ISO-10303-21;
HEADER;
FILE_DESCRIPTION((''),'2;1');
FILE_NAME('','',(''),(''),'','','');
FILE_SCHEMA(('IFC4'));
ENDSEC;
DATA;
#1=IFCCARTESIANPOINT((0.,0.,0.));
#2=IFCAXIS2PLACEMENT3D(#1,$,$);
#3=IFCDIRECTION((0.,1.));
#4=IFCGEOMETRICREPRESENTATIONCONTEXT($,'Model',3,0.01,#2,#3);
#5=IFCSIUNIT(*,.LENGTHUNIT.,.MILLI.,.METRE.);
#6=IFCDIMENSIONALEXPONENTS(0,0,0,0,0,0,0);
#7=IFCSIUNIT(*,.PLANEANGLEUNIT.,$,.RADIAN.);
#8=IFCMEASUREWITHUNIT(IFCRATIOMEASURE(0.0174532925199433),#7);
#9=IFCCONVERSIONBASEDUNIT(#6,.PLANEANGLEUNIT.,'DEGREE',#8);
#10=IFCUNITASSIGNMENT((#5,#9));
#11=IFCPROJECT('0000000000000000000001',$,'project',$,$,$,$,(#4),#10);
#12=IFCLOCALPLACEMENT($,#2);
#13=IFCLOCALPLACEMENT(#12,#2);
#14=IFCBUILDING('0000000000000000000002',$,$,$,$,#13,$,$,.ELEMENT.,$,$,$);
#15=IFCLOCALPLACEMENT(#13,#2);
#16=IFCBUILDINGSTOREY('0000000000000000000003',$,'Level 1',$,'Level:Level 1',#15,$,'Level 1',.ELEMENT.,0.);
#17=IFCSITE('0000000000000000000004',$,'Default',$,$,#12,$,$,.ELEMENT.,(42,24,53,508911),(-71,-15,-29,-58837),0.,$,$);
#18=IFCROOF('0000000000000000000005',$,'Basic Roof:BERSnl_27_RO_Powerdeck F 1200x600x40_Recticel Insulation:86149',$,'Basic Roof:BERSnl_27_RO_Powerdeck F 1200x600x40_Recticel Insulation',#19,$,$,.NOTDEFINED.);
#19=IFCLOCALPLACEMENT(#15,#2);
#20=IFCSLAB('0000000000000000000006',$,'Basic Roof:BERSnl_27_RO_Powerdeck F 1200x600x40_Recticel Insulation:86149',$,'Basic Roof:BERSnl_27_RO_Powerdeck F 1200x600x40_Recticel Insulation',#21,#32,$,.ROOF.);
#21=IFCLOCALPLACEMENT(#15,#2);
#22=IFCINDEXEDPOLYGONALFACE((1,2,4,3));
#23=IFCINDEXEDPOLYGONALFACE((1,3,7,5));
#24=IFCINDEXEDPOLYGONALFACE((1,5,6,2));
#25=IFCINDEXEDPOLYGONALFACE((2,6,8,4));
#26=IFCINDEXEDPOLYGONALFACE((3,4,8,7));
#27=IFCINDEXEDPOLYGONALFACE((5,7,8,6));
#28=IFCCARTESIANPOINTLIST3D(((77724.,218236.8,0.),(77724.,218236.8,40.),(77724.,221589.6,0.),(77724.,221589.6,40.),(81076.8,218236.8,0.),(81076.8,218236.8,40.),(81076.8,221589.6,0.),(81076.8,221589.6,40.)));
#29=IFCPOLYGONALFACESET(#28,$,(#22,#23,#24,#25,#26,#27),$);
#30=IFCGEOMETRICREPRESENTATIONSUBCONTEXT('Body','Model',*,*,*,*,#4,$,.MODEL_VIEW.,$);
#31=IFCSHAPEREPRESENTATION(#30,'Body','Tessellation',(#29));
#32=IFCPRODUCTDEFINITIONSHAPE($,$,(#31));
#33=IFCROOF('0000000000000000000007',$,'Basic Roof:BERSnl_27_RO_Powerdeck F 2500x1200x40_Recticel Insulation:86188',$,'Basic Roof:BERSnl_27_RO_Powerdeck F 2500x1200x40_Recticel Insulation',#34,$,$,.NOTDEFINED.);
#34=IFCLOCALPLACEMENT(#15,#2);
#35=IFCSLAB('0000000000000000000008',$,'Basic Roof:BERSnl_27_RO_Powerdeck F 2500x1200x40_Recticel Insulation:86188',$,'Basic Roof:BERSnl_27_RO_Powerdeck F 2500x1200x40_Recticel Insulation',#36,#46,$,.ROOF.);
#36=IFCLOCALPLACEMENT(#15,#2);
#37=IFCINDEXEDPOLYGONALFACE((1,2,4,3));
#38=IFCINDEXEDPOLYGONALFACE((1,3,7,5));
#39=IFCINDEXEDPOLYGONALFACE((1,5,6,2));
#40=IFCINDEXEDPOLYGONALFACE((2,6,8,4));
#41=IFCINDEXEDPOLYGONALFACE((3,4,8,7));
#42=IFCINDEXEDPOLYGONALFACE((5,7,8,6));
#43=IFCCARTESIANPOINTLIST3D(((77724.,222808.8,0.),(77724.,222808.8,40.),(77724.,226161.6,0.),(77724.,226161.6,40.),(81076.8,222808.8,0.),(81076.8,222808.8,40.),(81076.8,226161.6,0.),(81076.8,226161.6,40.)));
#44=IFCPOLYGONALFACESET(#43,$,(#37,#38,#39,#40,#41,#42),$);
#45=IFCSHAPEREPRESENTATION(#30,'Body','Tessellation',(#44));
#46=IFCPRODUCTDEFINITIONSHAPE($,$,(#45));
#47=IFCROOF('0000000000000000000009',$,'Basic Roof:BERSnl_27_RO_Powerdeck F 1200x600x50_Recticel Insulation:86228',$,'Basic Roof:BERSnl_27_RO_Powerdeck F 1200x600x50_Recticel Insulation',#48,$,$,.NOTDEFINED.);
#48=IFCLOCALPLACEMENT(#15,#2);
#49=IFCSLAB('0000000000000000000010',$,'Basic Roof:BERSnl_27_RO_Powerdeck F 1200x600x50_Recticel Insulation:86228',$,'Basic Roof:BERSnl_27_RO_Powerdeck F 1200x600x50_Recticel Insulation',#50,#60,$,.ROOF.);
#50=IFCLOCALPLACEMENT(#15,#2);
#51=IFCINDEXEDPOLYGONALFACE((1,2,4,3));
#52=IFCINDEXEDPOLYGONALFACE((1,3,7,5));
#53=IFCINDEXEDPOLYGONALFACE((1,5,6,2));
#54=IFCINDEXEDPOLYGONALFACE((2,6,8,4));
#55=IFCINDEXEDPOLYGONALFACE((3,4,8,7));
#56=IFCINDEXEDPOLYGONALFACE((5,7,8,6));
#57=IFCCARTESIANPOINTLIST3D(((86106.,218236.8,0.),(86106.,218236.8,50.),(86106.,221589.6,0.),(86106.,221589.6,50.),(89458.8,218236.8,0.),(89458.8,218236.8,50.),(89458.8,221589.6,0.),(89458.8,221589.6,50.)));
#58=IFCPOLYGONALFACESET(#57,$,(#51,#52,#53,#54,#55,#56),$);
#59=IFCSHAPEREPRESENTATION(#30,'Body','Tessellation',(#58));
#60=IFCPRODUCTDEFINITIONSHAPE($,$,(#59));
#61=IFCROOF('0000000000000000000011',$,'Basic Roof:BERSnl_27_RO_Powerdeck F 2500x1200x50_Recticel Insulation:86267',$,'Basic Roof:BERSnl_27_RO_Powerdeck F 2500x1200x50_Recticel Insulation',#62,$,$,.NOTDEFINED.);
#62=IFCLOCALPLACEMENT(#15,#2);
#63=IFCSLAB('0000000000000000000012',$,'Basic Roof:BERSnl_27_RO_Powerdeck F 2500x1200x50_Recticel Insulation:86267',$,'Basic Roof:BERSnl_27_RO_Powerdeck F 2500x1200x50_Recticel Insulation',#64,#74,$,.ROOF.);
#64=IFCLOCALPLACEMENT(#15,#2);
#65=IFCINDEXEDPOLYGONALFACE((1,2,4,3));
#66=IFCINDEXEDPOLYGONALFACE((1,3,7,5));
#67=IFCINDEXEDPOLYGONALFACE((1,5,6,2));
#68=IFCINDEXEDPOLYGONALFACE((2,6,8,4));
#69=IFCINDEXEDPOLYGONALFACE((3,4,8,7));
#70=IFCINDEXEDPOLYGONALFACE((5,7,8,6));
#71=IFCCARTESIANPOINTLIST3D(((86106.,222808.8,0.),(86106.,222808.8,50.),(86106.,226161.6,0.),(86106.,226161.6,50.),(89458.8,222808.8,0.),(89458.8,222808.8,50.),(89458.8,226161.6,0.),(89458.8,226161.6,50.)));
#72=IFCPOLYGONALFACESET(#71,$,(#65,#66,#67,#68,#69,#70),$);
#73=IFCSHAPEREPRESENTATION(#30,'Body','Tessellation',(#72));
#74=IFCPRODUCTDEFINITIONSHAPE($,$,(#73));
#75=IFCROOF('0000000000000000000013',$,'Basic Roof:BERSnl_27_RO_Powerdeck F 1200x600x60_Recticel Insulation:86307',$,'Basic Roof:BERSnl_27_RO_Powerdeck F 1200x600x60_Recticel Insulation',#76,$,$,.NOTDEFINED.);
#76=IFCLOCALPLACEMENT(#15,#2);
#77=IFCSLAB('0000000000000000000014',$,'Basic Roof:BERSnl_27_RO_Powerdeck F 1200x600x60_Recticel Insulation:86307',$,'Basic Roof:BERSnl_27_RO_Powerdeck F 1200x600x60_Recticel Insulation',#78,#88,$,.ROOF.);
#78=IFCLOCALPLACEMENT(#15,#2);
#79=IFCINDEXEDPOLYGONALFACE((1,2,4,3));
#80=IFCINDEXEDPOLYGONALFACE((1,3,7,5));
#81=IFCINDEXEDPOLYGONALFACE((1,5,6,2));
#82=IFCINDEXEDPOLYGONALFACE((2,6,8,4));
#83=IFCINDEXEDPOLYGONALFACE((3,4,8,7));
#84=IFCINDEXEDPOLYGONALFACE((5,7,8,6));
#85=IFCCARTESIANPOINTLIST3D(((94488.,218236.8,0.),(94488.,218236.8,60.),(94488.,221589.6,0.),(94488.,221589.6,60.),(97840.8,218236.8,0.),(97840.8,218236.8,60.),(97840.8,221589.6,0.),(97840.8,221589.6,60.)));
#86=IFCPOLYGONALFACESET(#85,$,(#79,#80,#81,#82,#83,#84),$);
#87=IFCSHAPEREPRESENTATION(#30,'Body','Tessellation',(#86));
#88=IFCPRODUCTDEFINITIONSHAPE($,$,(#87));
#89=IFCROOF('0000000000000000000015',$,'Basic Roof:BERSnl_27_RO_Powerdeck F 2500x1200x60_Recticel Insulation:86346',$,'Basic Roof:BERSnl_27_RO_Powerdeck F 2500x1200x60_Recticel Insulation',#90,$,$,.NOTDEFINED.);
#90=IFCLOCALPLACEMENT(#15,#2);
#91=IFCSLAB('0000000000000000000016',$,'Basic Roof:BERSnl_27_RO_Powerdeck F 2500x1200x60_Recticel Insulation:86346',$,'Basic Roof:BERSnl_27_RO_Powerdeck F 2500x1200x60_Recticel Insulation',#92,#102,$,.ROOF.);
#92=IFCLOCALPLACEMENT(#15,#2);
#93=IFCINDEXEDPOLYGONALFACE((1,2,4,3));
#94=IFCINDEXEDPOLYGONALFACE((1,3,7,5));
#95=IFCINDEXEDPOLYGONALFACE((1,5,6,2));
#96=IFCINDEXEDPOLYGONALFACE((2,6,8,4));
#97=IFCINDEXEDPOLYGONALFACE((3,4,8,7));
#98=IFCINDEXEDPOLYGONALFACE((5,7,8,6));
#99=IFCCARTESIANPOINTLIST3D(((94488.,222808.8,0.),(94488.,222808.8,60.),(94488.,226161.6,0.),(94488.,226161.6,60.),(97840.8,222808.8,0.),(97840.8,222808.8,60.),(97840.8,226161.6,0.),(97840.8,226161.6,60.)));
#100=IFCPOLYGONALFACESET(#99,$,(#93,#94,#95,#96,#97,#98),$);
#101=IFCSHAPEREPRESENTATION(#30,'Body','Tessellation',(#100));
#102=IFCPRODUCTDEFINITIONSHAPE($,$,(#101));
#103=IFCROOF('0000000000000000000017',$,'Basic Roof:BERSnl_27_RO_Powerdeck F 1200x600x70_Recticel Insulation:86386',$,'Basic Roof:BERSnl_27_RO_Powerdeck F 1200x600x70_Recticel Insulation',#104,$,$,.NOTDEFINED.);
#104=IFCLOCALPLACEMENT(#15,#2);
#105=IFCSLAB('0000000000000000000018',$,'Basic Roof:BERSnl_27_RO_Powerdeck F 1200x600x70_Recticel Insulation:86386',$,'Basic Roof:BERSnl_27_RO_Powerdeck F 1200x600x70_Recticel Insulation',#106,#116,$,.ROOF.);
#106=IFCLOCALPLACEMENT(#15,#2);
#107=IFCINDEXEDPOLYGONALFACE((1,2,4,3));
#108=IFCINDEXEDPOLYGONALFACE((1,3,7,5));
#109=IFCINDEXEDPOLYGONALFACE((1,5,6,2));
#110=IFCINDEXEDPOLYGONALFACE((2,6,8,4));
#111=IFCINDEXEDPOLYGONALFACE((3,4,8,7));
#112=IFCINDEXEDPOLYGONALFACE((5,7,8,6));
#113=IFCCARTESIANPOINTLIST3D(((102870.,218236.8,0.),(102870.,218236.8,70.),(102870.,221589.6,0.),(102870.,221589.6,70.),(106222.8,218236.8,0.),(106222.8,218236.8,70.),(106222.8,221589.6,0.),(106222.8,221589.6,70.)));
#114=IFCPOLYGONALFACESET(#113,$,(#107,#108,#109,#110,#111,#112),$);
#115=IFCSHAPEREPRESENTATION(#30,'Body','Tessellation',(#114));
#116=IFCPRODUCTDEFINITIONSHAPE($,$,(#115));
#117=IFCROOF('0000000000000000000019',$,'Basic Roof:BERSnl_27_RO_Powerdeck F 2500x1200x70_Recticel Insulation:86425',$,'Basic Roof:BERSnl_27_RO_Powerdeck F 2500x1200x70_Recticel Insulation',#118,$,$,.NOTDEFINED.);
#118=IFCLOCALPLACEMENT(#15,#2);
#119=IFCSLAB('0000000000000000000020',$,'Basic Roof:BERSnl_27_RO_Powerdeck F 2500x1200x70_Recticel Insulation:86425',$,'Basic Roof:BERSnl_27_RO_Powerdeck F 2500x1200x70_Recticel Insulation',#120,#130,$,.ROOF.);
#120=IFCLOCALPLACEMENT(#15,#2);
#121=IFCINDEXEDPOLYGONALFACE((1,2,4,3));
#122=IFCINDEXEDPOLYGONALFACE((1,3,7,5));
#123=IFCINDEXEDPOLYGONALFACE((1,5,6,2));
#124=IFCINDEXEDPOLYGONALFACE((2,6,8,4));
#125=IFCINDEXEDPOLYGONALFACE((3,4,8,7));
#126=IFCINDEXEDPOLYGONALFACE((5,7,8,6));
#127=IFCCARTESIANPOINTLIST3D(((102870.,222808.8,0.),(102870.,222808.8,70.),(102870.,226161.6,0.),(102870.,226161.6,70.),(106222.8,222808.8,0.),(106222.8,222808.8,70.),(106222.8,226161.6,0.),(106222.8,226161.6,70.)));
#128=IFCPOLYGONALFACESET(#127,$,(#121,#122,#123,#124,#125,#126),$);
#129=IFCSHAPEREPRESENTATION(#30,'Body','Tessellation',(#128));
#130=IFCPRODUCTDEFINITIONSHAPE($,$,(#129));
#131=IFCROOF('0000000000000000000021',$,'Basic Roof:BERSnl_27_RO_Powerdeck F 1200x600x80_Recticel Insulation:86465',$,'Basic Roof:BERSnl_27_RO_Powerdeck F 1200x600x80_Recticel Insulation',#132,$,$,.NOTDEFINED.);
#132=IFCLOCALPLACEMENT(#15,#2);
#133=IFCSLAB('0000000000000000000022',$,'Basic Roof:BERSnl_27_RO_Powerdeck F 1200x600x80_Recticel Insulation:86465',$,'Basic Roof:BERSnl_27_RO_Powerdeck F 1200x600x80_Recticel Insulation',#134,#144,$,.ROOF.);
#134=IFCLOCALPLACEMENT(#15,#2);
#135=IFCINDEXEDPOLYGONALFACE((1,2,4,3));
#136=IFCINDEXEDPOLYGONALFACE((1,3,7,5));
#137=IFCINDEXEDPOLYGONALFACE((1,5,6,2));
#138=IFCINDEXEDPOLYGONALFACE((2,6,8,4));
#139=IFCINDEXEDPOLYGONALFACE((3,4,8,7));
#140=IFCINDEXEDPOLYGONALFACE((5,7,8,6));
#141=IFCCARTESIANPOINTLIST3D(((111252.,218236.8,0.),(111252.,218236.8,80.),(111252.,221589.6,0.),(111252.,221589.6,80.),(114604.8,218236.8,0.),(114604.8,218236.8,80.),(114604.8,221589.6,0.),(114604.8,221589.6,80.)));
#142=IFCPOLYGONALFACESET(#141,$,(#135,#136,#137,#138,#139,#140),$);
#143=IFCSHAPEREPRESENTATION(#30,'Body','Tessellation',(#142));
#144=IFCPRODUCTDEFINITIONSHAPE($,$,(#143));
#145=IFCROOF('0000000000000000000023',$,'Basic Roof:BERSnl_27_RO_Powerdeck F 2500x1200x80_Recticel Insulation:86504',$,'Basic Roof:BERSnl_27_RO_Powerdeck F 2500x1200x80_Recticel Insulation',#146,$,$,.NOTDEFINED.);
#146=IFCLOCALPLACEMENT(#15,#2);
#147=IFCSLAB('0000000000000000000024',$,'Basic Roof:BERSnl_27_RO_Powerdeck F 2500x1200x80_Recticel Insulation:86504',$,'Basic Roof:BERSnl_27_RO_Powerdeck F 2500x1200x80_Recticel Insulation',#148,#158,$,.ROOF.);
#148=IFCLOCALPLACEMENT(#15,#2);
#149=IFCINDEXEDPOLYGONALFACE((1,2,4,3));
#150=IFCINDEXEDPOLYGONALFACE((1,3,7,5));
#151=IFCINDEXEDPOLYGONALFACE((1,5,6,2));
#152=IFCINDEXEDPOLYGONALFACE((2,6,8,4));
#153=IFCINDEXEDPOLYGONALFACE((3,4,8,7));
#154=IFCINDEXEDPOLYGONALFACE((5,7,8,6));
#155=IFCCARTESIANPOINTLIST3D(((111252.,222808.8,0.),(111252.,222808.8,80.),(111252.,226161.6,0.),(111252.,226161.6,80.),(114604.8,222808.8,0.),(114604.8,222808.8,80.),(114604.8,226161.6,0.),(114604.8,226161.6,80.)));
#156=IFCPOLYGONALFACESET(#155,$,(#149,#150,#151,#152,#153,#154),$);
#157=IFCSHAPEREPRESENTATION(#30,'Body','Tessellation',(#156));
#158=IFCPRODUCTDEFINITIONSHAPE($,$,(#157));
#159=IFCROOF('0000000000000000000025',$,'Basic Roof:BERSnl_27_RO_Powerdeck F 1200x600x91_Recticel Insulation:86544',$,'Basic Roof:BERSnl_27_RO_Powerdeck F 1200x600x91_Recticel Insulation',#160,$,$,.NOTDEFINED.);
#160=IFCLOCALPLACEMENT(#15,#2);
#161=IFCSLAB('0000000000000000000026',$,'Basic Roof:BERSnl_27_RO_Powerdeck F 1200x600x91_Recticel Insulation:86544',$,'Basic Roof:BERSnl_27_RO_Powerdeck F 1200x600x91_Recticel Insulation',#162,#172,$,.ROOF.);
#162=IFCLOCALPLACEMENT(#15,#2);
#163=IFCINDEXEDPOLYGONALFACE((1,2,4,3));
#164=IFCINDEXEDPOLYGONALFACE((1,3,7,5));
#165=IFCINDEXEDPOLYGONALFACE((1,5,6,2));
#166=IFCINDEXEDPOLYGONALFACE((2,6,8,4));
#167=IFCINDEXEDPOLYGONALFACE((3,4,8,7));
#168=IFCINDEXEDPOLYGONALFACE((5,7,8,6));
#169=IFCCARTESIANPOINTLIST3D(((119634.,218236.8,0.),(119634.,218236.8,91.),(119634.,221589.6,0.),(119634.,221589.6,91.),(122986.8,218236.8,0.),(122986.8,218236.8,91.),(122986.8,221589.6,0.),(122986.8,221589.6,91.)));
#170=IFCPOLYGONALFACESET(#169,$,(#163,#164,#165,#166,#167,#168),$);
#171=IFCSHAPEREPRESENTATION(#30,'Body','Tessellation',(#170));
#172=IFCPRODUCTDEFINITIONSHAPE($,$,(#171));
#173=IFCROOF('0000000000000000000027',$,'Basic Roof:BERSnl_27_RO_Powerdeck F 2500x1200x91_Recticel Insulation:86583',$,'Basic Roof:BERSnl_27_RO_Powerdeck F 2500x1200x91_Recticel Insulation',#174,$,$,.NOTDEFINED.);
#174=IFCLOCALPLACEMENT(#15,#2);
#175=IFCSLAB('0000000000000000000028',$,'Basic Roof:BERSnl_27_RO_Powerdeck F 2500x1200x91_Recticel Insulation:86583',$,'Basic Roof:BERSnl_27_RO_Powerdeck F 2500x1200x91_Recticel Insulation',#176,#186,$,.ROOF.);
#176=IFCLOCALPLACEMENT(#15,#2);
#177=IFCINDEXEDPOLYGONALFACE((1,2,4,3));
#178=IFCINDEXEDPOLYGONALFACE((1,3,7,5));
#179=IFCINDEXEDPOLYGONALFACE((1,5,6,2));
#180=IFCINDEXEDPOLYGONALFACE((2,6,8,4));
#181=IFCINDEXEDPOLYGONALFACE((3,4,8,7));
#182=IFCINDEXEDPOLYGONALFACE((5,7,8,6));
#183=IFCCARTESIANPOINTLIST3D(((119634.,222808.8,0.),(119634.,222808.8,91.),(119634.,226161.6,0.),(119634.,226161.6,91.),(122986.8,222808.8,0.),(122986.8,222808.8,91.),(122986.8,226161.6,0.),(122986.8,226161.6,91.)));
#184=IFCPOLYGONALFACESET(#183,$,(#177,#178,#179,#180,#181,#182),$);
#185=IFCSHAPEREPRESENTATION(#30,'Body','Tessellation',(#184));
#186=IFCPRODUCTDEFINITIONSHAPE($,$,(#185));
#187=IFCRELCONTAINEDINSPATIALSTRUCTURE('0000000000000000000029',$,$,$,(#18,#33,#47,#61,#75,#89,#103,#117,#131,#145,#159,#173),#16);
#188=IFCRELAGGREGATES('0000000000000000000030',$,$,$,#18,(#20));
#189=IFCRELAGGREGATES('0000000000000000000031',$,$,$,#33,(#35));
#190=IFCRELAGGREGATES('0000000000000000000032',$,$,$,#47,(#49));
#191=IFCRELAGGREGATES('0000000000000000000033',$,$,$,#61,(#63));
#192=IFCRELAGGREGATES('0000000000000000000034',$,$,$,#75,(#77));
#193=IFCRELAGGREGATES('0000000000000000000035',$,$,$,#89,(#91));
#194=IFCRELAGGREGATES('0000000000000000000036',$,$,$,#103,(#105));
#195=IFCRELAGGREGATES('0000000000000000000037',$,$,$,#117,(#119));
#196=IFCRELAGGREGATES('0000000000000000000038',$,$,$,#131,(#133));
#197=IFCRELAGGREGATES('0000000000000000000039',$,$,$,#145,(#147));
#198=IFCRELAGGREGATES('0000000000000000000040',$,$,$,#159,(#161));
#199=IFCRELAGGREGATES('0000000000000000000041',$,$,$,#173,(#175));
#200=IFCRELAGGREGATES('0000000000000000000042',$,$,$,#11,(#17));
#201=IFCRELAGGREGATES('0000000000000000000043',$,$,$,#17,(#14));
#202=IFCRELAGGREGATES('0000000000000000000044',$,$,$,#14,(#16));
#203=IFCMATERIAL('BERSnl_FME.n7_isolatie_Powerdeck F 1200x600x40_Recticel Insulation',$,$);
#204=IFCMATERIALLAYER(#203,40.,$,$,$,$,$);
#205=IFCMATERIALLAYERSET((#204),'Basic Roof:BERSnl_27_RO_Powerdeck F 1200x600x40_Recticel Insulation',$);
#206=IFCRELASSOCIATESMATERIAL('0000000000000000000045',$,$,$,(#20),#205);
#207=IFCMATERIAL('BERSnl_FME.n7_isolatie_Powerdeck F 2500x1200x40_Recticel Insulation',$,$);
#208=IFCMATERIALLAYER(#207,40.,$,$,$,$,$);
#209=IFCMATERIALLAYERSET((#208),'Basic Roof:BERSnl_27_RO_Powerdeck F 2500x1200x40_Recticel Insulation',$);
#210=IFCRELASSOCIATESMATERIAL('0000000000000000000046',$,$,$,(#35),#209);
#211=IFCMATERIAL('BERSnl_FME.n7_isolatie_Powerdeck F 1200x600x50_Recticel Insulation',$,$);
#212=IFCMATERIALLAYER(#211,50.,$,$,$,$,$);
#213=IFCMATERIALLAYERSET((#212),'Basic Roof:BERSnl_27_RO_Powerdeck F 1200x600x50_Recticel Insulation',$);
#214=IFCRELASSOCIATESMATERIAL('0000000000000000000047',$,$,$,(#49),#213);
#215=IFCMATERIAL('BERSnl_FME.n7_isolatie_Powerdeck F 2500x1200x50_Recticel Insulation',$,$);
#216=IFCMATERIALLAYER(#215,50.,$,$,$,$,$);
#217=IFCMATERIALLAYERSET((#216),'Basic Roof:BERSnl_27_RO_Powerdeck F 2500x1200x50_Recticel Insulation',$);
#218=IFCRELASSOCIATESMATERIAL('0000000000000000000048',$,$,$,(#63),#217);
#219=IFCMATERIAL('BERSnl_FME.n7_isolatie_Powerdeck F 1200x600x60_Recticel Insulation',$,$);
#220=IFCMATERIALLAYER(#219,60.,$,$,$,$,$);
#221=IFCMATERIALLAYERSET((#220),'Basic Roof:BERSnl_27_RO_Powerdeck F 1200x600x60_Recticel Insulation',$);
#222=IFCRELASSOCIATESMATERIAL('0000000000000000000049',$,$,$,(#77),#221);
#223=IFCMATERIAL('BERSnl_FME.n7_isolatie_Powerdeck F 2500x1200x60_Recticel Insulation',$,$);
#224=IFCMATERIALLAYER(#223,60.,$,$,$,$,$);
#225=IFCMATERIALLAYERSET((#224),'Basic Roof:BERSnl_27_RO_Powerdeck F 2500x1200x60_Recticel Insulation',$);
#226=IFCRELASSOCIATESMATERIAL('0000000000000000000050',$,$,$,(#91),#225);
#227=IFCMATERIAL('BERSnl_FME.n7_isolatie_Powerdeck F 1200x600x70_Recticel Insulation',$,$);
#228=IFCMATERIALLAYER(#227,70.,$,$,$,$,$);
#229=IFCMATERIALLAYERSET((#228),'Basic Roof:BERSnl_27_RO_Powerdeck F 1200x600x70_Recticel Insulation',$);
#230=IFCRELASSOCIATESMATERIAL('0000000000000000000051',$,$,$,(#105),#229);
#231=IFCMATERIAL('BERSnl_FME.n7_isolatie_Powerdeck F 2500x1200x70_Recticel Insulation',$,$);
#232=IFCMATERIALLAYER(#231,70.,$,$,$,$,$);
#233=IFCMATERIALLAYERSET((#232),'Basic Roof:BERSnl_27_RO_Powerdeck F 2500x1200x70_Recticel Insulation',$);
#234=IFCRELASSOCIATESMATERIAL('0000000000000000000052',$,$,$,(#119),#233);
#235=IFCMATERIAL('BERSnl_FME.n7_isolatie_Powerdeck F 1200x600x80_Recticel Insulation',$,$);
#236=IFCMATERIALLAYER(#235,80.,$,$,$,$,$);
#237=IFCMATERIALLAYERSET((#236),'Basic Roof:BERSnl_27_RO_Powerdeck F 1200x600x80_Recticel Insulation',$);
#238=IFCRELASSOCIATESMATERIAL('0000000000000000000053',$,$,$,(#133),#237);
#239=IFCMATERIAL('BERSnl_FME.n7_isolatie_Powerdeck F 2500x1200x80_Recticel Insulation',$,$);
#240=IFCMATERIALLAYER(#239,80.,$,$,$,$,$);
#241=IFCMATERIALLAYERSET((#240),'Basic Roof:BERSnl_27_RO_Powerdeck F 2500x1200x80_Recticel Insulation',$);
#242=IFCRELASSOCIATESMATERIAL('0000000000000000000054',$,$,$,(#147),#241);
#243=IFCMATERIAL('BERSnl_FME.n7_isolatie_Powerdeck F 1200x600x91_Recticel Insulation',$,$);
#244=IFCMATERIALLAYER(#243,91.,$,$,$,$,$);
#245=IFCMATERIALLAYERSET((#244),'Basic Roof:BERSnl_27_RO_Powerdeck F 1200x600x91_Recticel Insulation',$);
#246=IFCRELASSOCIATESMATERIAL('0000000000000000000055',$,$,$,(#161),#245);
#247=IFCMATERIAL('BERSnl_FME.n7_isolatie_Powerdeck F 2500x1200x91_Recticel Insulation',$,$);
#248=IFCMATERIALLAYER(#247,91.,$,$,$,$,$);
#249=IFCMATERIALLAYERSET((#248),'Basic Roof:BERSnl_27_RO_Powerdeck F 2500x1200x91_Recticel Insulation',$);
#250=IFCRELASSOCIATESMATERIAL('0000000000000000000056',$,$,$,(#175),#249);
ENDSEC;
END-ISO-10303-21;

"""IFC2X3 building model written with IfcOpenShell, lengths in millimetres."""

from ifc_helpers import new_model, entity, si_unit, converted_unit, direction, frame, frame_2d, origin, place, context, subcontext, project, spatial, rectangle, extrude, material, layer, layer_set, element, aggregate, save


model = new_model("IFC2X3")

# Units and contexts
model_context = context("Model", 3, precision=0.01, world=origin(), true_north=direction((0.0, 1.0)))
body_context = subcontext(model_context, "Body", "Model", "MODEL_VIEW")
ifc_project = project(units=[si_unit("LENGTHUNIT", "METRE", prefix="MILLI"), converted_unit("PLANEANGLEUNIT", "DEGREE", entity("IfcRatioMeasure", 0.0174532925199433), si_unit("PLANEANGLEUNIT", "RADIAN"), dimensions=[0, 0, 0, 0, 0, 0, 0])], contexts=[model_context])

# Site, building, storey
site_placement = place(None, origin())
site = spatial("IfcSite", under=ifc_project, at=site_placement, Name="Default", CompositionType="ELEMENT", RefLatitude=(42, 24, 53, 508911), RefLongitude=(-71, -15, -29, -58837), RefElevation=0.0)
building_placement = place(site_placement, origin())
building = spatial("IfcBuilding", under=site, at=building_placement, CompositionType="ELEMENT")
storey_placement = place(building_placement, origin())
storey = spatial("IfcBuildingStorey", under=building, at=storey_placement, Name="Level 1", ObjectType="Level:Level 1", LongName="Level 1", CompositionType="ELEMENT", Elevation=0.0)

# Roofs, slabs
roof_1_placement = place(storey_placement, frame((77724.0, 218236.8, 0.0)))
roof_1 = element("IfcRoof", 1, at=roof_1_placement, inside=storey, Name="Basic Roof:BERSnl_27_RO_Powerdeck F 1200x600x40_Recticel Insulation:86149", ObjectType="Basic Roof:BERSnl_27_RO_Powerdeck F 1200x600x40_Recticel Insulation", ShapeType="NOTDEFINED")
ifc_material_1 = material(Name="BERSnl_FME.n7_isolatie_Powerdeck F 1200x600x40_Recticel Insulation")
ifc_layer_1 = layer(ifc_material_1, 40.0)
ifc_layer_set_1 = layer_set([ifc_layer_1], Name="Basic Roof:BERSnl_27_RO_Powerdeck F 1200x600x40_Recticel Insulation")
slab_1_placement = place(roof_1_placement, origin())
slab_1 = element("IfcSlab", 2, at=slab_1_placement, material=ifc_layer_set_1, Name="Basic Roof:BERSnl_27_RO_Powerdeck F 1200x600x40_Recticel Insulation:86149", ObjectType="Basic Roof:BERSnl_27_RO_Powerdeck F 1200x600x40_Recticel Insulation", PredefinedType="ROOF", context=body_context, shape_type="SweptSolid", body=[
    extrude(rectangle(XDim=3352.8, YDim=3352.8, at=frame_2d((0.0, 0.0), x_axis=(-1.0, 0.0))), frame((1676.4, 1676.4, 0.0)), (0.0, 0.0, 1.0), 40.0),
])
aggregate(roof_1, [slab_1])
roof_2_placement = place(storey_placement, frame((77724.0, 222808.8, 0.0)))
roof_2 = element("IfcRoof", 3, at=roof_2_placement, inside=storey, Name="Basic Roof:BERSnl_27_RO_Powerdeck F 2500x1200x40_Recticel Insulation:86188", ObjectType="Basic Roof:BERSnl_27_RO_Powerdeck F 2500x1200x40_Recticel Insulation", ShapeType="NOTDEFINED")
ifc_material_2 = material(Name="BERSnl_FME.n7_isolatie_Powerdeck F 2500x1200x40_Recticel Insulation")
ifc_layer_2 = layer(ifc_material_2, 40.0)
ifc_layer_set_2 = layer_set([ifc_layer_2], Name="Basic Roof:BERSnl_27_RO_Powerdeck F 2500x1200x40_Recticel Insulation")
slab_2_placement = place(roof_2_placement, origin())
slab_2 = element("IfcSlab", 4, at=slab_2_placement, material=ifc_layer_set_2, Name="Basic Roof:BERSnl_27_RO_Powerdeck F 2500x1200x40_Recticel Insulation:86188", ObjectType="Basic Roof:BERSnl_27_RO_Powerdeck F 2500x1200x40_Recticel Insulation", PredefinedType="ROOF", context=body_context, shape_type="SweptSolid", body=[
    extrude(rectangle(XDim=3352.8, YDim=3352.8, at=frame_2d((0.0, 0.0), x_axis=(-1.0, 0.0))), frame((1676.4, 1676.4, 0.0)), (0.0, 0.0, 1.0), 40.0),
])
aggregate(roof_2, [slab_2])
roof_3_placement = place(storey_placement, frame((86106.0, 218236.8, 0.0)))
roof_3 = element("IfcRoof", 5, at=roof_3_placement, inside=storey, Name="Basic Roof:BERSnl_27_RO_Powerdeck F 1200x600x50_Recticel Insulation:86228", ObjectType="Basic Roof:BERSnl_27_RO_Powerdeck F 1200x600x50_Recticel Insulation", ShapeType="NOTDEFINED")
ifc_material_3 = material(Name="BERSnl_FME.n7_isolatie_Powerdeck F 1200x600x50_Recticel Insulation")
ifc_layer_3 = layer(ifc_material_3, 50.0)
ifc_layer_set_3 = layer_set([ifc_layer_3], Name="Basic Roof:BERSnl_27_RO_Powerdeck F 1200x600x50_Recticel Insulation")
slab_3_placement = place(roof_3_placement, origin())
slab_3 = element("IfcSlab", 6, at=slab_3_placement, material=ifc_layer_set_3, Name="Basic Roof:BERSnl_27_RO_Powerdeck F 1200x600x50_Recticel Insulation:86228", ObjectType="Basic Roof:BERSnl_27_RO_Powerdeck F 1200x600x50_Recticel Insulation", PredefinedType="ROOF", context=body_context, shape_type="SweptSolid", body=[
    extrude(rectangle(XDim=3352.8, YDim=3352.8, at=frame_2d((0.0, 0.0), x_axis=(-1.0, 0.0))), frame((1676.4, 1676.4, 0.0)), (0.0, 0.0, 1.0), 50.0),
])
aggregate(roof_3, [slab_3])
roof_4_placement = place(storey_placement, frame((86106.0, 222808.8, 0.0)))
roof_4 = element("IfcRoof", 7, at=roof_4_placement, inside=storey, Name="Basic Roof:BERSnl_27_RO_Powerdeck F 2500x1200x50_Recticel Insulation:86267", ObjectType="Basic Roof:BERSnl_27_RO_Powerdeck F 2500x1200x50_Recticel Insulation", ShapeType="NOTDEFINED")
ifc_material_4 = material(Name="BERSnl_FME.n7_isolatie_Powerdeck F 2500x1200x50_Recticel Insulation")
ifc_layer_4 = layer(ifc_material_4, 50.0)
ifc_layer_set_4 = layer_set([ifc_layer_4], Name="Basic Roof:BERSnl_27_RO_Powerdeck F 2500x1200x50_Recticel Insulation")
slab_4_placement = place(roof_4_placement, origin())
slab_4 = element("IfcSlab", 8, at=slab_4_placement, material=ifc_layer_set_4, Name="Basic Roof:BERSnl_27_RO_Powerdeck F 2500x1200x50_Recticel Insulation:86267", ObjectType="Basic Roof:BERSnl_27_RO_Powerdeck F 2500x1200x50_Recticel Insulation", PredefinedType="ROOF", context=body_context, shape_type="SweptSolid", body=[
    extrude(rectangle(XDim=3352.8, YDim=3352.8, at=frame_2d((0.0, 0.0), x_axis=(-1.0, 0.0))), frame((1676.4, 1676.4, 0.0)), (0.0, 0.0, 1.0), 50.0),
])
aggregate(roof_4, [slab_4])
roof_5_placement = place(storey_placement, frame((94488.0, 218236.8, 0.0)))
roof_5 = element("IfcRoof", 9, at=roof_5_placement, inside=storey, Name="Basic Roof:BERSnl_27_RO_Powerdeck F 1200x600x60_Recticel Insulation:86307", ObjectType="Basic Roof:BERSnl_27_RO_Powerdeck F 1200x600x60_Recticel Insulation", ShapeType="NOTDEFINED")
ifc_material_5 = material(Name="BERSnl_FME.n7_isolatie_Powerdeck F 1200x600x60_Recticel Insulation")
ifc_layer_5 = layer(ifc_material_5, 60.0)
ifc_layer_set_5 = layer_set([ifc_layer_5], Name="Basic Roof:BERSnl_27_RO_Powerdeck F 1200x600x60_Recticel Insulation")
slab_5_placement = place(roof_5_placement, origin())
slab_5 = element("IfcSlab", 10, at=slab_5_placement, material=ifc_layer_set_5, Name="Basic Roof:BERSnl_27_RO_Powerdeck F 1200x600x60_Recticel Insulation:86307", ObjectType="Basic Roof:BERSnl_27_RO_Powerdeck F 1200x600x60_Recticel Insulation", PredefinedType="ROOF", context=body_context, shape_type="SweptSolid", body=[
    extrude(rectangle(XDim=3352.8, YDim=3352.8, at=frame_2d((0.0, 0.0), x_axis=(-1.0, 0.0))), frame((1676.4, 1676.4, 0.0)), (0.0, 0.0, 1.0), 60.0),
])
aggregate(roof_5, [slab_5])
roof_6_placement = place(storey_placement, frame((94488.0, 222808.8, 0.0)))
roof_6 = element("IfcRoof", 11, at=roof_6_placement, inside=storey, Name="Basic Roof:BERSnl_27_RO_Powerdeck F 2500x1200x60_Recticel Insulation:86346", ObjectType="Basic Roof:BERSnl_27_RO_Powerdeck F 2500x1200x60_Recticel Insulation", ShapeType="NOTDEFINED")
ifc_material_6 = material(Name="BERSnl_FME.n7_isolatie_Powerdeck F 2500x1200x60_Recticel Insulation")
ifc_layer_6 = layer(ifc_material_6, 60.0)
ifc_layer_set_6 = layer_set([ifc_layer_6], Name="Basic Roof:BERSnl_27_RO_Powerdeck F 2500x1200x60_Recticel Insulation")
slab_6_placement = place(roof_6_placement, origin())
slab_6 = element("IfcSlab", 12, at=slab_6_placement, material=ifc_layer_set_6, Name="Basic Roof:BERSnl_27_RO_Powerdeck F 2500x1200x60_Recticel Insulation:86346", ObjectType="Basic Roof:BERSnl_27_RO_Powerdeck F 2500x1200x60_Recticel Insulation", PredefinedType="ROOF", context=body_context, shape_type="SweptSolid", body=[
    extrude(rectangle(XDim=3352.8, YDim=3352.8, at=frame_2d((0.0, 0.0), x_axis=(-1.0, 0.0))), frame((1676.4, 1676.4, 0.0)), (0.0, 0.0, 1.0), 60.0),
])
aggregate(roof_6, [slab_6])
roof_7_placement = place(storey_placement, frame((102870.0, 218236.8, 0.0)))
roof_7 = element("IfcRoof", 13, at=roof_7_placement, inside=storey, Name="Basic Roof:BERSnl_27_RO_Powerdeck F 1200x600x70_Recticel Insulation:86386", ObjectType="Basic Roof:BERSnl_27_RO_Powerdeck F 1200x600x70_Recticel Insulation", ShapeType="NOTDEFINED")
ifc_material_7 = material(Name="BERSnl_FME.n7_isolatie_Powerdeck F 1200x600x70_Recticel Insulation")
ifc_layer_7 = layer(ifc_material_7, 70.0)
ifc_layer_set_7 = layer_set([ifc_layer_7], Name="Basic Roof:BERSnl_27_RO_Powerdeck F 1200x600x70_Recticel Insulation")
slab_7_placement = place(roof_7_placement, origin())
slab_7 = element("IfcSlab", 14, at=slab_7_placement, material=ifc_layer_set_7, Name="Basic Roof:BERSnl_27_RO_Powerdeck F 1200x600x70_Recticel Insulation:86386", ObjectType="Basic Roof:BERSnl_27_RO_Powerdeck F 1200x600x70_Recticel Insulation", PredefinedType="ROOF", context=body_context, shape_type="SweptSolid", body=[
    extrude(rectangle(XDim=3352.8, YDim=3352.8, at=frame_2d((0.0, 0.0), x_axis=(-1.0, 0.0))), frame((1676.4, 1676.4, 0.0)), (0.0, 0.0, 1.0), 70.0),
])
aggregate(roof_7, [slab_7])
roof_8_placement = place(storey_placement, frame((102870.0, 222808.8, 0.0)))
roof_8 = element("IfcRoof", 15, at=roof_8_placement, inside=storey, Name="Basic Roof:BERSnl_27_RO_Powerdeck F 2500x1200x70_Recticel Insulation:86425", ObjectType="Basic Roof:BERSnl_27_RO_Powerdeck F 2500x1200x70_Recticel Insulation", ShapeType="NOTDEFINED")
ifc_material_8 = material(Name="BERSnl_FME.n7_isolatie_Powerdeck F 2500x1200x70_Recticel Insulation")
ifc_layer_8 = layer(ifc_material_8, 70.0)
ifc_layer_set_8 = layer_set([ifc_layer_8], Name="Basic Roof:BERSnl_27_RO_Powerdeck F 2500x1200x70_Recticel Insulation")
slab_8_placement = place(roof_8_placement, origin())
slab_8 = element("IfcSlab", 16, at=slab_8_placement, material=ifc_layer_set_8, Name="Basic Roof:BERSnl_27_RO_Powerdeck F 2500x1200x70_Recticel Insulation:86425", ObjectType="Basic Roof:BERSnl_27_RO_Powerdeck F 2500x1200x70_Recticel Insulation", PredefinedType="ROOF", context=body_context, shape_type="SweptSolid", body=[
    extrude(rectangle(XDim=3352.8, YDim=3352.8, at=frame_2d((0.0, 0.0), x_axis=(-1.0, 0.0))), frame((1676.4, 1676.4, 0.0)), (0.0, 0.0, 1.0), 70.0),
])
aggregate(roof_8, [slab_8])
roof_9_placement = place(storey_placement, frame((111252.0, 218236.8, 0.0)))
roof_9 = element("IfcRoof", 17, at=roof_9_placement, inside=storey, Name="Basic Roof:BERSnl_27_RO_Powerdeck F 1200x600x80_Recticel Insulation:86465", ObjectType="Basic Roof:BERSnl_27_RO_Powerdeck F 1200x600x80_Recticel Insulation", ShapeType="NOTDEFINED")
ifc_material_9 = material(Name="BERSnl_FME.n7_isolatie_Powerdeck F 1200x600x80_Recticel Insulation")
ifc_layer_9 = layer(ifc_material_9, 80.0)
ifc_layer_set_9 = layer_set([ifc_layer_9], Name="Basic Roof:BERSnl_27_RO_Powerdeck F 1200x600x80_Recticel Insulation")
slab_9_placement = place(roof_9_placement, origin())
slab_9 = element("IfcSlab", 18, at=slab_9_placement, material=ifc_layer_set_9, Name="Basic Roof:BERSnl_27_RO_Powerdeck F 1200x600x80_Recticel Insulation:86465", ObjectType="Basic Roof:BERSnl_27_RO_Powerdeck F 1200x600x80_Recticel Insulation", PredefinedType="ROOF", context=body_context, shape_type="SweptSolid", body=[
    extrude(rectangle(XDim=3352.8, YDim=3352.8, at=frame_2d((0.0, 0.0), x_axis=(-1.0, 0.0))), frame((1676.4, 1676.4, 0.0)), (0.0, 0.0, 1.0), 80.0),
])
aggregate(roof_9, [slab_9])
roof_10_placement = place(storey_placement, frame((111252.0, 222808.8, 0.0)))
roof_10 = element("IfcRoof", 19, at=roof_10_placement, inside=storey, Name="Basic Roof:BERSnl_27_RO_Powerdeck F 2500x1200x80_Recticel Insulation:86504", ObjectType="Basic Roof:BERSnl_27_RO_Powerdeck F 2500x1200x80_Recticel Insulation", ShapeType="NOTDEFINED")
ifc_material_10 = material(Name="BERSnl_FME.n7_isolatie_Powerdeck F 2500x1200x80_Recticel Insulation")
ifc_layer_10 = layer(ifc_material_10, 80.0)
ifc_layer_set_10 = layer_set([ifc_layer_10], Name="Basic Roof:BERSnl_27_RO_Powerdeck F 2500x1200x80_Recticel Insulation")
slab_10_placement = place(roof_10_placement, origin())
slab_10 = element("IfcSlab", 20, at=slab_10_placement, material=ifc_layer_set_10, Name="Basic Roof:BERSnl_27_RO_Powerdeck F 2500x1200x80_Recticel Insulation:86504", ObjectType="Basic Roof:BERSnl_27_RO_Powerdeck F 2500x1200x80_Recticel Insulation", PredefinedType="ROOF", context=body_context, shape_type="SweptSolid", body=[
    extrude(rectangle(XDim=3352.8, YDim=3352.8, at=frame_2d((0.0, 0.0), x_axis=(-1.0, 0.0))), frame((1676.4, 1676.4, 0.0)), (0.0, 0.0, 1.0), 80.0),
])
aggregate(roof_10, [slab_10])
roof_11_placement = place(storey_placement, frame((119634.0, 218236.8, 0.0)))
roof_11 = element("IfcRoof", 21, at=roof_11_placement, inside=storey, Name="Basic Roof:BERSnl_27_RO_Powerdeck F 1200x600x91_Recticel Insulation:86544", ObjectType="Basic Roof:BERSnl_27_RO_Powerdeck F 1200x600x91_Recticel Insulation", ShapeType="NOTDEFINED")
ifc_material_11 = material(Name="BERSnl_FME.n7_isolatie_Powerdeck F 1200x600x91_Recticel Insulation")
ifc_layer_11 = layer(ifc_material_11, 91.0)
ifc_layer_set_11 = layer_set([ifc_layer_11], Name="Basic Roof:BERSnl_27_RO_Powerdeck F 1200x600x91_Recticel Insulation")
slab_11_placement = place(roof_11_placement, origin())
slab_11 = element("IfcSlab", 22, at=slab_11_placement, material=ifc_layer_set_11, Name="Basic Roof:BERSnl_27_RO_Powerdeck F 1200x600x91_Recticel Insulation:86544", ObjectType="Basic Roof:BERSnl_27_RO_Powerdeck F 1200x600x91_Recticel Insulation", PredefinedType="ROOF", context=body_context, shape_type="SweptSolid", body=[
    extrude(rectangle(XDim=3352.8, YDim=3352.8, at=frame_2d((0.0, 0.0), x_axis=(-1.0, 0.0))), frame((1676.4, 1676.4, 0.0)), (0.0, 0.0, 1.0), 91.0),
])
aggregate(roof_11, [slab_11])
roof_12_placement = place(storey_placement, frame((119634.0, 222808.8, 0.0)))
roof_12 = element("IfcRoof", 23, at=roof_12_placement, inside=storey, Name="Basic Roof:BERSnl_27_RO_Powerdeck F 2500x1200x91_Recticel Insulation:86583", ObjectType="Basic Roof:BERSnl_27_RO_Powerdeck F 2500x1200x91_Recticel Insulation", ShapeType="NOTDEFINED")
ifc_material_12 = material(Name="BERSnl_FME.n7_isolatie_Powerdeck F 2500x1200x91_Recticel Insulation")
ifc_layer_12 = layer(ifc_material_12, 91.0)
ifc_layer_set_12 = layer_set([ifc_layer_12], Name="Basic Roof:BERSnl_27_RO_Powerdeck F 2500x1200x91_Recticel Insulation")
slab_12_placement = place(roof_12_placement, origin())
slab_12 = element("IfcSlab", 24, at=slab_12_placement, material=ifc_layer_set_12, Name="Basic Roof:BERSnl_27_RO_Powerdeck F 2500x1200x91_Recticel Insulation:86583", ObjectType="Basic Roof:BERSnl_27_RO_Powerdeck F 2500x1200x91_Recticel Insulation", PredefinedType="ROOF", context=body_context, shape_type="SweptSolid", body=[
    extrude(rectangle(XDim=3352.8, YDim=3352.8, at=frame_2d((0.0, 0.0), x_axis=(-1.0, 0.0))), frame((1676.4, 1676.4, 0.0)), (0.0, 0.0, 1.0), 91.0),
])
aggregate(roof_12, [slab_12])

save(model, "model.ifc")
